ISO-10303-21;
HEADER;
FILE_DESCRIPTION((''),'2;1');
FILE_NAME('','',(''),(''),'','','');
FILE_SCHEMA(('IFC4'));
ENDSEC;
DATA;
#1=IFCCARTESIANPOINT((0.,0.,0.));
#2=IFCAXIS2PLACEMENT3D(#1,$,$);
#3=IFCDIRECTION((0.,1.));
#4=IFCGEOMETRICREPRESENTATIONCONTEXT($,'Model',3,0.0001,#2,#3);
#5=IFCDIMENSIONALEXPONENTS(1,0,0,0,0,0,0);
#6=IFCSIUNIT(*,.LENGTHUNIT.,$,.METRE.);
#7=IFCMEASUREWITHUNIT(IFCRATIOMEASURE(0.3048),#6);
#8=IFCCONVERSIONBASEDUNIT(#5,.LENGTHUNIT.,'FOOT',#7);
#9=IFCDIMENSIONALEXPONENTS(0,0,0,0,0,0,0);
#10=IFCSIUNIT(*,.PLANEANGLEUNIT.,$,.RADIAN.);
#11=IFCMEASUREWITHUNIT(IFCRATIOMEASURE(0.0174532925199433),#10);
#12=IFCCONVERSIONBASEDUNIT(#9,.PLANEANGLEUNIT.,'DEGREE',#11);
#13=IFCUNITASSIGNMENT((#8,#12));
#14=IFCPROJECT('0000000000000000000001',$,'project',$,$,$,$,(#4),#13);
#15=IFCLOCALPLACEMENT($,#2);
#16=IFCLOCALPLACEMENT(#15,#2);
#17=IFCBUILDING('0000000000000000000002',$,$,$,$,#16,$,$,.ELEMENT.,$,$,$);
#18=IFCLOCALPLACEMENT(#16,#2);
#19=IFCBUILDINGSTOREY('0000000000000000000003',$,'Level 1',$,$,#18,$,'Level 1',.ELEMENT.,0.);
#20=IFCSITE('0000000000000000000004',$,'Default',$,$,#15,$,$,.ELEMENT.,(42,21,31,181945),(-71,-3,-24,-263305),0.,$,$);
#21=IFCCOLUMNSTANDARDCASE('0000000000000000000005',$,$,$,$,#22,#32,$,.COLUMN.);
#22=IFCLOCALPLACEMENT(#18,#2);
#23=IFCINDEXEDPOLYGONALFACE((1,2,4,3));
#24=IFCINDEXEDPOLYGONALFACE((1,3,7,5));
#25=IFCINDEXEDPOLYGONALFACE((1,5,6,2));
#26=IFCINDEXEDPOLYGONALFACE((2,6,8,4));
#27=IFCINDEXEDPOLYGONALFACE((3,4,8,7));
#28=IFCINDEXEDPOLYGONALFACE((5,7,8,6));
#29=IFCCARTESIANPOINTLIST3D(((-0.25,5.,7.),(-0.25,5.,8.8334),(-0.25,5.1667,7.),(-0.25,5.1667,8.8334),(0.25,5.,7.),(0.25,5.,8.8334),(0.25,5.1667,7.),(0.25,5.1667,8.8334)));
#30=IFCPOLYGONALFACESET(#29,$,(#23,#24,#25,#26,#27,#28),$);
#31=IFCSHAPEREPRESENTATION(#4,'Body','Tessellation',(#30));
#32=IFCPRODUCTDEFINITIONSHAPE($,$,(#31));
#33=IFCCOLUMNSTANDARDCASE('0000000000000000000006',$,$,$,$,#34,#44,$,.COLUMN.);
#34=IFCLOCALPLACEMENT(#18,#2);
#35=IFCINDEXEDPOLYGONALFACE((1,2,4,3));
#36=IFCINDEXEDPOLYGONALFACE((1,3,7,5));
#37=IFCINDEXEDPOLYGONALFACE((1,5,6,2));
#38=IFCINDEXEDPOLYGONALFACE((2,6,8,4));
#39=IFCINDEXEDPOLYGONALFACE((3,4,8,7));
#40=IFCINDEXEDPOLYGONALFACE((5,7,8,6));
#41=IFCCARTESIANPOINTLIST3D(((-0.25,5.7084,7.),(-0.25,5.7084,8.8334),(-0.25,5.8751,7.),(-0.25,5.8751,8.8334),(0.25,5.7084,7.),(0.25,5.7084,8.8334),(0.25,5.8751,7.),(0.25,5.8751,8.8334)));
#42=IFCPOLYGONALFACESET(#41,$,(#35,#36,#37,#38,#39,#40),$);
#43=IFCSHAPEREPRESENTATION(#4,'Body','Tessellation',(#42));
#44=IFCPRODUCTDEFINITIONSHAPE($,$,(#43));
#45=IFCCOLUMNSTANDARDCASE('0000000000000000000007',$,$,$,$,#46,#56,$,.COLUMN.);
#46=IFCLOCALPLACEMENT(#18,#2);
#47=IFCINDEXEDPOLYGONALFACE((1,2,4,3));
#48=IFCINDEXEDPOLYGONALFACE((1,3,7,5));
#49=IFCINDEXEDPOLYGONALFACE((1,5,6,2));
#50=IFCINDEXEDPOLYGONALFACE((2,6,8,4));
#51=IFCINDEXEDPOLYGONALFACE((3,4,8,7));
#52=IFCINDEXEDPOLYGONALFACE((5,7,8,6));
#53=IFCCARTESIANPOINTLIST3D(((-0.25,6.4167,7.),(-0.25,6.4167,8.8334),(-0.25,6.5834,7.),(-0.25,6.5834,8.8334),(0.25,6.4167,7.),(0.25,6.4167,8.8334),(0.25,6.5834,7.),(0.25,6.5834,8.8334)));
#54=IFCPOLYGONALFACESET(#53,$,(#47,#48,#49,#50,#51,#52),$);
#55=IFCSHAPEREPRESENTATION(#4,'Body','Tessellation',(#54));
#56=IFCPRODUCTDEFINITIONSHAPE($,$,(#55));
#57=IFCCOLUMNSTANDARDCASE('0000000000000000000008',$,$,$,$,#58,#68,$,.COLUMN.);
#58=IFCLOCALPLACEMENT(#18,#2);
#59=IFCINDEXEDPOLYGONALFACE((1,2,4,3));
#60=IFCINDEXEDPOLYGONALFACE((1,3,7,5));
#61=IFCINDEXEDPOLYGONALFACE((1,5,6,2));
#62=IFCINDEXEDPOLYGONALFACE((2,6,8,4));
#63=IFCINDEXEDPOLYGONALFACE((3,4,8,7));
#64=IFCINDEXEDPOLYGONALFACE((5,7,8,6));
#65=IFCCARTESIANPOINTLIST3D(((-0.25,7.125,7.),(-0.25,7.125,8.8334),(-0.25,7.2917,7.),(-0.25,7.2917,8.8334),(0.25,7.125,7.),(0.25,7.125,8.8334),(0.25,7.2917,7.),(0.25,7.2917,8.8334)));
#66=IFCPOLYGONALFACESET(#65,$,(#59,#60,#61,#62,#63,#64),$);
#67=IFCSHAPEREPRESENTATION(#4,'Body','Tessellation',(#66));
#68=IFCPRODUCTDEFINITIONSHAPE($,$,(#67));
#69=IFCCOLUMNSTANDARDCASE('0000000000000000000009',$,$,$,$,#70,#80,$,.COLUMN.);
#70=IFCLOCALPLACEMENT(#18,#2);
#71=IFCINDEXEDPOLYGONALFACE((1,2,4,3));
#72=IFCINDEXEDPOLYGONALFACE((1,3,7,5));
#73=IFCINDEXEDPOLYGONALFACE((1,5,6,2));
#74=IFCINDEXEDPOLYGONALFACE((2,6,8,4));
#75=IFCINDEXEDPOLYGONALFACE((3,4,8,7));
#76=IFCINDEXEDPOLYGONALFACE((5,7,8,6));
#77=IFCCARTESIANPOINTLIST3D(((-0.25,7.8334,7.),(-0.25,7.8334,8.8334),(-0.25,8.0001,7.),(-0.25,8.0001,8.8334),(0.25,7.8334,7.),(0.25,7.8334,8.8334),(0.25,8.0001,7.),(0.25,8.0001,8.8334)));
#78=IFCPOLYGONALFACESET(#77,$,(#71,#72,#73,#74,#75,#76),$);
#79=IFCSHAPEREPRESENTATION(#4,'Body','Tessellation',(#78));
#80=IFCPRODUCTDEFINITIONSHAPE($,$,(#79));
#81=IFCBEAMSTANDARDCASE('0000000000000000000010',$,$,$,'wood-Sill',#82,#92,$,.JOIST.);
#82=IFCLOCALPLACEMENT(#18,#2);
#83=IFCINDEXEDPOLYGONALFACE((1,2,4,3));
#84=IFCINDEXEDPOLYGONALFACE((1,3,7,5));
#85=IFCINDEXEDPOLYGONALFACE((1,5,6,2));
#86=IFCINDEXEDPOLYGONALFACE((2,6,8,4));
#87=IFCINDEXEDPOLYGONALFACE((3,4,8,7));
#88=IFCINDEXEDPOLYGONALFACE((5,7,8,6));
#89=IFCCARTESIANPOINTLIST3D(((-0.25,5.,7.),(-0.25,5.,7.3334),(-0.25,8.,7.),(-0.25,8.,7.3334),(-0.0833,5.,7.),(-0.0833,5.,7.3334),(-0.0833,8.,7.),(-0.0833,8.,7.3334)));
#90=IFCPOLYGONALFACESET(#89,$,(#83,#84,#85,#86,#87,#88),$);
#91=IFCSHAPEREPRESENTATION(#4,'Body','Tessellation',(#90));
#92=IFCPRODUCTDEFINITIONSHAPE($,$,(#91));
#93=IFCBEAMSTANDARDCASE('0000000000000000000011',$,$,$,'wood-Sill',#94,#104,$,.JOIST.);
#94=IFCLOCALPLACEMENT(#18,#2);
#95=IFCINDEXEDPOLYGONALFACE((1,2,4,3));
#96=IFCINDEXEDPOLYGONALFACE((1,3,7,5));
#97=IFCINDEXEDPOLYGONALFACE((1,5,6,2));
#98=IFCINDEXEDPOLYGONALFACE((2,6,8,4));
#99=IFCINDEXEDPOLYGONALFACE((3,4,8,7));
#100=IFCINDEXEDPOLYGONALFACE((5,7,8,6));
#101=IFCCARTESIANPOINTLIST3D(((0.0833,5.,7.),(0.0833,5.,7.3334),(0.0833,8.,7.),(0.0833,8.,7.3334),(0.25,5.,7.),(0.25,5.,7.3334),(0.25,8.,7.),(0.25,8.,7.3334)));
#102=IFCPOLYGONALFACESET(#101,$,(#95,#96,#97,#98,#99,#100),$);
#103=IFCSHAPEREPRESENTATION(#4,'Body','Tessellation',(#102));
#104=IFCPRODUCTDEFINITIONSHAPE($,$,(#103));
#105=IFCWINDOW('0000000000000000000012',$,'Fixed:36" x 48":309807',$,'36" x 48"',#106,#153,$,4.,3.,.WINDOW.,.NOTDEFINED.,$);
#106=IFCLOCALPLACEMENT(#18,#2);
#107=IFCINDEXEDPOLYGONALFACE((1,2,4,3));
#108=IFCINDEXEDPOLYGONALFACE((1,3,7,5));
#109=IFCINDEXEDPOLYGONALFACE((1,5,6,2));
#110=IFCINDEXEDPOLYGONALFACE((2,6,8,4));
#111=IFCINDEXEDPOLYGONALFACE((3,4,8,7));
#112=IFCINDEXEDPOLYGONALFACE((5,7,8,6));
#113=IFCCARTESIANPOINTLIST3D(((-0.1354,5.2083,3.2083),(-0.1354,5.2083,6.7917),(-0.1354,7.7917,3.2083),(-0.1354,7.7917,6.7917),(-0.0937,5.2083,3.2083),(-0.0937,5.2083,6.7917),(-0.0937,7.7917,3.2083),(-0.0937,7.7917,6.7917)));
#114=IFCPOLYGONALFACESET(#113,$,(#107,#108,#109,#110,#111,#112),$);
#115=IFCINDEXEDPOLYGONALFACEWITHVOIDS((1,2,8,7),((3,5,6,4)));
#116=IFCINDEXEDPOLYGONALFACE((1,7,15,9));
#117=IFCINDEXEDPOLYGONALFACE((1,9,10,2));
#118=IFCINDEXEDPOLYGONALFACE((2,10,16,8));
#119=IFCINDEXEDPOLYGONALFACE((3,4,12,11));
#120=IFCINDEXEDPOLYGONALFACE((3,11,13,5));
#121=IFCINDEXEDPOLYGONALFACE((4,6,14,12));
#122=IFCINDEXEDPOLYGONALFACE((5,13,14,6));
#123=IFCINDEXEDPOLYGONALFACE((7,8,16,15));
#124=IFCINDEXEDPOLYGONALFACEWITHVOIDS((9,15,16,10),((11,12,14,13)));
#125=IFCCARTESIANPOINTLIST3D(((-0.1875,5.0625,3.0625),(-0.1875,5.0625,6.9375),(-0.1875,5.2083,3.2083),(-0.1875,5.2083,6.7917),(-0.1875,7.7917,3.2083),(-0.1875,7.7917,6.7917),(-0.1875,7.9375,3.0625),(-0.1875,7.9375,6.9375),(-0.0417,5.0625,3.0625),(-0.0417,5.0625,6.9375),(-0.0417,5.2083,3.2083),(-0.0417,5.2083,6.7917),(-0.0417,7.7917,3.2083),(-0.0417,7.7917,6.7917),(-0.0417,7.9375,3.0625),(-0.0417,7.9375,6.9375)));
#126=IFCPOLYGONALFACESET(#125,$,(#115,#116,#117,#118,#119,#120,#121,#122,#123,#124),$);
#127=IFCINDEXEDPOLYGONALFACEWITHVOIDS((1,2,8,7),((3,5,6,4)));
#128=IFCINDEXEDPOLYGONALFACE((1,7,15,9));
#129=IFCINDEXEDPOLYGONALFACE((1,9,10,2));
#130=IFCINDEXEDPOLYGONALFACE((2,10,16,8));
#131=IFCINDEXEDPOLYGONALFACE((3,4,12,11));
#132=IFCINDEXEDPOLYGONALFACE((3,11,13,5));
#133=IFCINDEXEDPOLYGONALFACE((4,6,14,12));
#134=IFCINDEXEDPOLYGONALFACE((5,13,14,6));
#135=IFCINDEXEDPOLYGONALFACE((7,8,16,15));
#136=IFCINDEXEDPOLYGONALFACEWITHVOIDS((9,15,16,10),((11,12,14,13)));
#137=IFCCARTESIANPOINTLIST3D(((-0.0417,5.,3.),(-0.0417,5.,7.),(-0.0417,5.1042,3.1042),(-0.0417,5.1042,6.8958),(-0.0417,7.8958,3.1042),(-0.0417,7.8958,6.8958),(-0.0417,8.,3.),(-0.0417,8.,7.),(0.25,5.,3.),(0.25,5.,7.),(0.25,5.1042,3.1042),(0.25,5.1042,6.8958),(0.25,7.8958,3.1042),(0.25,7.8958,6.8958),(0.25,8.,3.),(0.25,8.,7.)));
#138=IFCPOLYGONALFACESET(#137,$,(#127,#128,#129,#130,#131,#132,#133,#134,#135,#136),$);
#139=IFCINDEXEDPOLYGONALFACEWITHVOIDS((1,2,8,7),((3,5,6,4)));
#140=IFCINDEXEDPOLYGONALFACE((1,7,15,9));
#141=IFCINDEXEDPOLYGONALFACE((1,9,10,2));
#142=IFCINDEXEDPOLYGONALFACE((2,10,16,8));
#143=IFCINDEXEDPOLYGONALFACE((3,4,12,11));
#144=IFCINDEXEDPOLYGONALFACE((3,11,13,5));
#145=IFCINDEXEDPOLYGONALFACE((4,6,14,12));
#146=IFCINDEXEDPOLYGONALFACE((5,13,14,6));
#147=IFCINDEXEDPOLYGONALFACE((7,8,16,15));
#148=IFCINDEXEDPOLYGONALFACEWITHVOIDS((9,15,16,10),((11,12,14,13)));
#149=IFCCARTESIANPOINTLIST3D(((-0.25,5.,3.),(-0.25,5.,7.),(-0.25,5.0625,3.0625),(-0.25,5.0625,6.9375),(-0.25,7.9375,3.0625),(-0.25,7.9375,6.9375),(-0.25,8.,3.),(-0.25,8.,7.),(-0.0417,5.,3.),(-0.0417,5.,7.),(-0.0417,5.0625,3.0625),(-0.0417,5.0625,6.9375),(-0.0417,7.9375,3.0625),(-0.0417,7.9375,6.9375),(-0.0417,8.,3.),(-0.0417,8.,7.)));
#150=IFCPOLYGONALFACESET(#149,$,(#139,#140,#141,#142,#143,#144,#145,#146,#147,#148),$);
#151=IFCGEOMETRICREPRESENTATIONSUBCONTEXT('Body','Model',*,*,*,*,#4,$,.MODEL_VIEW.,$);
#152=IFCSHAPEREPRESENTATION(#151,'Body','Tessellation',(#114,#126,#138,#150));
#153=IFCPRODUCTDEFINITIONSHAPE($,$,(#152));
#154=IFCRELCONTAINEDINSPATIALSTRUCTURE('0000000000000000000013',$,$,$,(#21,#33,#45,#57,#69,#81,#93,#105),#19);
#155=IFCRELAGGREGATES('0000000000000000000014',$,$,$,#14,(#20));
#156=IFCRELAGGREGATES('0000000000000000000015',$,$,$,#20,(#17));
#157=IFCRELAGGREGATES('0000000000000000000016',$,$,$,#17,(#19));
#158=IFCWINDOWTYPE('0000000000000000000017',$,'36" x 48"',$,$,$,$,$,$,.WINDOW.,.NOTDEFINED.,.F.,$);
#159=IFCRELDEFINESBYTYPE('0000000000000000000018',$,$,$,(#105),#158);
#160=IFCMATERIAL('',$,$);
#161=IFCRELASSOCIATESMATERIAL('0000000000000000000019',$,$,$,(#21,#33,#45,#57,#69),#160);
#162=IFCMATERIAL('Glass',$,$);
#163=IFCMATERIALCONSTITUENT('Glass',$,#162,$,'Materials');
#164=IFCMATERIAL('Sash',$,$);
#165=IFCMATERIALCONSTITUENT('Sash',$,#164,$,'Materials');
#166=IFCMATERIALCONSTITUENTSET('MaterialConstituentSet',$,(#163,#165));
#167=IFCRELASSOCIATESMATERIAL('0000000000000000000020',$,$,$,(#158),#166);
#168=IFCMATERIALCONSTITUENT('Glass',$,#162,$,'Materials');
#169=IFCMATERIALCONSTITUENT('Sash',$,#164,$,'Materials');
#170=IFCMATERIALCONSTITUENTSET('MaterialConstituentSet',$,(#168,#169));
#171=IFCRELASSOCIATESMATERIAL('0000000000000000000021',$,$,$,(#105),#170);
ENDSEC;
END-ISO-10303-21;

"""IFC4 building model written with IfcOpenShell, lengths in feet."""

from ifc_helpers import new_model, entity, si_unit, converted_unit, direction, frame, frame_2d, origin, origin_with_axes, place, context, subcontext, project, spatial, polyline, rectangle, outline, extrude, source, transform, mapped, material, constituent, constituent_set, type_object, type_shapes, element, save


model = new_model("IFC4")

# Units and contexts
model_context = context("Model", 3, precision=0.0001, world=origin(), true_north=direction((0.0, 1.0)))
body_context = subcontext(model_context, "Body", "Model", "MODEL_VIEW")
ifc_project = project(units=[converted_unit("LENGTHUNIT", "FOOT", entity("IfcRatioMeasure", 0.3048), si_unit("LENGTHUNIT", "METRE"), dimensions=[1, 0, 0, 0, 0, 0, 0]), converted_unit("PLANEANGLEUNIT", "DEGREE", entity("IfcRatioMeasure", 0.0174532925199433), si_unit("PLANEANGLEUNIT", "RADIAN"), dimensions=[0, 0, 0, 0, 0, 0, 0])], contexts=[model_context])

# Site, building, storey
site_placement = place(None, origin())
site = spatial("IfcSite", under=ifc_project, at=site_placement, Name="Default", CompositionType="ELEMENT", RefLatitude=(42, 21, 31, 181945), RefLongitude=(-71, -3, -24, -263305), RefElevation=0.0)
building_placement = place(site_placement, origin())
building = spatial("IfcBuilding", under=site, at=building_placement, CompositionType="ELEMENT")
storey_placement = place(building_placement, origin())
storey = spatial("IfcBuildingStorey", under=building, at=storey_placement, Name="Level 1", LongName="Level 1", CompositionType="ELEMENT", Elevation=0.0)

# Columns
placement_1 = place(storey_placement, frame((0.0, -0.25, 0.0), z_axis=(0.0, 0.0, 1.0), x_axis=(0.0, 1.0, 0.0)))
ifc_material_1 = material(Name="")
for number, where, z_axis, x_axis in (
    (1, (5.3333, 0.0, 7.0), (0.0, 0.0, 1.0), (1.0, 0.0, 0.0)),
    (2, (6.0417, 0.0, 7.0), (0.0, 0.0, 1.0), (1.0, 0.0, 0.0)),
    (3, (6.75, 0.0, 7.0), (0.0, 0.0, 1.0), (1.0, 0.0, 0.0)),
    (4, (7.4583, 0.0, 7.0), (0.0, 0.0, 1.0), (1.0, 0.0, 0.0)),
    (5, (8.1667, 0.0, 7.0), (0.0, 0.0, 1.0), (1.0, 0.0, 0.0)),
):
    element("IfcColumnStandardCase", number, at=place(placement_1, frame(where, z_axis=z_axis, x_axis=x_axis)), inside=storey, material=ifc_material_1, PredefinedType="COLUMN", context=model_context, shape_type="SweptSolid", body=[
        extrude(rectangle(XDim=0.1667, YDim=0.5), origin(), (0.0, 0.0, 1.0), 1.8334),
    ])

# Beams
for number, where, z_axis, x_axis in (
    (6, (5.25, 0.1667, 7.1667), (1.0, 0.0, 0.0), (0.0, 0.0, 1.0)),
    (7, (5.25, -0.1667, 7.1667), (1.0, 0.0, 0.0), (0.0, 0.0, 1.0)),
):
    element("IfcBeamStandardCase", number, at=place(placement_1, frame(where, z_axis=z_axis, x_axis=x_axis)), inside=storey, ObjectType="wood-Sill", PredefinedType="JOIST", context=model_context, shape_type="SweptSolid", body=[
        extrude(rectangle(XDim=0.3333, YDim=0.1667), origin_with_axes(), (0.0, 0.0, 1.0), 3.0),
    ])

# Window
ifc_material_2 = material(Name="Glass")
ifc_constituent_1 = constituent(ifc_material_2, Name="Glass", Category="Materials")
ifc_material_3 = material(Name="Sash")
ifc_constituent_2 = constituent(ifc_material_3, Name="Sash", Category="Materials")
ifc_constituent_set_1 = constituent_set(constituents=[ifc_constituent_1, ifc_constituent_2], Name="MaterialConstituentSet")
ifc_constituent_3 = constituent(ifc_material_2, Name="Glass", Category="Materials")
ifc_constituent_4 = constituent(ifc_material_3, Name="Sash", Category="Materials")
ifc_constituent_set_2 = constituent_set(constituents=[ifc_constituent_3, ifc_constituent_4], Name="MaterialConstituentSet")
window_type = type_object("IfcWindowType", Name="36\" x 48\"", ParameterTakesPrecedence=False, PartitioningType="NOTDEFINED", PredefinedType="WINDOW", material=ifc_constituent_set_2)
shared_shape = source(origin(), body_context, "Body", "SweptSolid", [
    extrude(rectangle(XDim=0.0417, YDim=2.5833, at=frame_2d((0.0, 0.0), x_axis=(1.0, 0.0))), frame((1.5, 0.3646, 0.2083), z_axis=(0.0, 0.0, 1.0), x_axis=(0.0, 1.0, 0.0)), (0.0, 0.0, 1.0), 3.5833),
    extrude(outline(polyline([(-1.4375, -1.9375), (1.4375, -1.9375), (1.4375, 1.9375), (-1.4375, 1.9375), (-1.4375, -1.9375)]), holes=[polyline([(-1.2917, -1.7917), (-1.2917, 1.7917), (1.2917, 1.7917), (1.2917, -1.7917), (-1.2917, -1.7917)])]), frame((1.5, 0.2917, 2.0), z_axis=(0.0, 1.0, 0.0), x_axis=(1.0, 0.0, 0.0)), (0.0, 0.0, 1.0), 0.1458),
    extrude(outline(polyline([(-1.5, -2.0), (1.5, -2.0), (1.5, 2.0), (-1.5, 2.0), (-1.5, -2.0)]), holes=[polyline([(-1.3958, -1.8958), (-1.3958, 1.8958), (1.3958, 1.8958), (1.3958, -1.8958), (-1.3958, -1.8958)])]), frame((1.5, 0.0, 2.0), z_axis=(0.0, 1.0, 0.0), x_axis=(1.0, 0.0, 0.0)), (0.0, 0.0, 1.0), 0.2917),
    extrude(outline(polyline([(-2.0, -1.5), (2.0, -1.5), (2.0, 1.5), (-2.0, 1.5), (-2.0, -1.5)]), holes=[polyline([(-1.9375, -1.4375), (-1.9375, 1.4375), (1.9375, 1.4375), (1.9375, -1.4375), (-1.9375, -1.4375)])]), frame((1.5, 0.2917, 2.0), z_axis=(0.0, 1.0, 0.0), x_axis=(0.0, 0.0, -1.0)), (0.0, 0.0, 1.0), 0.2083),
])
type_shapes(window_type, [shared_shape])
placement_2 = place(placement_1, frame((5.25, -0.25, 3.0)))
window_placement = place(placement_2, origin())
element("IfcWindow", 8, at=window_placement, inside=storey, type_object=window_type, material=ifc_constituent_set_1, Name="Fixed:36\" x 48\":309807", ObjectType="36\" x 48\"", OverallHeight=4.0, OverallWidth=3.0, PartitioningType="NOTDEFINED", PredefinedType="WINDOW", context=body_context, shape_type="MappedRepresentation", body=[
    mapped(shared_shape, transform((0.0, 0.0, 0.0), scale=1.0)),
])

save(model, "model.ifc")
